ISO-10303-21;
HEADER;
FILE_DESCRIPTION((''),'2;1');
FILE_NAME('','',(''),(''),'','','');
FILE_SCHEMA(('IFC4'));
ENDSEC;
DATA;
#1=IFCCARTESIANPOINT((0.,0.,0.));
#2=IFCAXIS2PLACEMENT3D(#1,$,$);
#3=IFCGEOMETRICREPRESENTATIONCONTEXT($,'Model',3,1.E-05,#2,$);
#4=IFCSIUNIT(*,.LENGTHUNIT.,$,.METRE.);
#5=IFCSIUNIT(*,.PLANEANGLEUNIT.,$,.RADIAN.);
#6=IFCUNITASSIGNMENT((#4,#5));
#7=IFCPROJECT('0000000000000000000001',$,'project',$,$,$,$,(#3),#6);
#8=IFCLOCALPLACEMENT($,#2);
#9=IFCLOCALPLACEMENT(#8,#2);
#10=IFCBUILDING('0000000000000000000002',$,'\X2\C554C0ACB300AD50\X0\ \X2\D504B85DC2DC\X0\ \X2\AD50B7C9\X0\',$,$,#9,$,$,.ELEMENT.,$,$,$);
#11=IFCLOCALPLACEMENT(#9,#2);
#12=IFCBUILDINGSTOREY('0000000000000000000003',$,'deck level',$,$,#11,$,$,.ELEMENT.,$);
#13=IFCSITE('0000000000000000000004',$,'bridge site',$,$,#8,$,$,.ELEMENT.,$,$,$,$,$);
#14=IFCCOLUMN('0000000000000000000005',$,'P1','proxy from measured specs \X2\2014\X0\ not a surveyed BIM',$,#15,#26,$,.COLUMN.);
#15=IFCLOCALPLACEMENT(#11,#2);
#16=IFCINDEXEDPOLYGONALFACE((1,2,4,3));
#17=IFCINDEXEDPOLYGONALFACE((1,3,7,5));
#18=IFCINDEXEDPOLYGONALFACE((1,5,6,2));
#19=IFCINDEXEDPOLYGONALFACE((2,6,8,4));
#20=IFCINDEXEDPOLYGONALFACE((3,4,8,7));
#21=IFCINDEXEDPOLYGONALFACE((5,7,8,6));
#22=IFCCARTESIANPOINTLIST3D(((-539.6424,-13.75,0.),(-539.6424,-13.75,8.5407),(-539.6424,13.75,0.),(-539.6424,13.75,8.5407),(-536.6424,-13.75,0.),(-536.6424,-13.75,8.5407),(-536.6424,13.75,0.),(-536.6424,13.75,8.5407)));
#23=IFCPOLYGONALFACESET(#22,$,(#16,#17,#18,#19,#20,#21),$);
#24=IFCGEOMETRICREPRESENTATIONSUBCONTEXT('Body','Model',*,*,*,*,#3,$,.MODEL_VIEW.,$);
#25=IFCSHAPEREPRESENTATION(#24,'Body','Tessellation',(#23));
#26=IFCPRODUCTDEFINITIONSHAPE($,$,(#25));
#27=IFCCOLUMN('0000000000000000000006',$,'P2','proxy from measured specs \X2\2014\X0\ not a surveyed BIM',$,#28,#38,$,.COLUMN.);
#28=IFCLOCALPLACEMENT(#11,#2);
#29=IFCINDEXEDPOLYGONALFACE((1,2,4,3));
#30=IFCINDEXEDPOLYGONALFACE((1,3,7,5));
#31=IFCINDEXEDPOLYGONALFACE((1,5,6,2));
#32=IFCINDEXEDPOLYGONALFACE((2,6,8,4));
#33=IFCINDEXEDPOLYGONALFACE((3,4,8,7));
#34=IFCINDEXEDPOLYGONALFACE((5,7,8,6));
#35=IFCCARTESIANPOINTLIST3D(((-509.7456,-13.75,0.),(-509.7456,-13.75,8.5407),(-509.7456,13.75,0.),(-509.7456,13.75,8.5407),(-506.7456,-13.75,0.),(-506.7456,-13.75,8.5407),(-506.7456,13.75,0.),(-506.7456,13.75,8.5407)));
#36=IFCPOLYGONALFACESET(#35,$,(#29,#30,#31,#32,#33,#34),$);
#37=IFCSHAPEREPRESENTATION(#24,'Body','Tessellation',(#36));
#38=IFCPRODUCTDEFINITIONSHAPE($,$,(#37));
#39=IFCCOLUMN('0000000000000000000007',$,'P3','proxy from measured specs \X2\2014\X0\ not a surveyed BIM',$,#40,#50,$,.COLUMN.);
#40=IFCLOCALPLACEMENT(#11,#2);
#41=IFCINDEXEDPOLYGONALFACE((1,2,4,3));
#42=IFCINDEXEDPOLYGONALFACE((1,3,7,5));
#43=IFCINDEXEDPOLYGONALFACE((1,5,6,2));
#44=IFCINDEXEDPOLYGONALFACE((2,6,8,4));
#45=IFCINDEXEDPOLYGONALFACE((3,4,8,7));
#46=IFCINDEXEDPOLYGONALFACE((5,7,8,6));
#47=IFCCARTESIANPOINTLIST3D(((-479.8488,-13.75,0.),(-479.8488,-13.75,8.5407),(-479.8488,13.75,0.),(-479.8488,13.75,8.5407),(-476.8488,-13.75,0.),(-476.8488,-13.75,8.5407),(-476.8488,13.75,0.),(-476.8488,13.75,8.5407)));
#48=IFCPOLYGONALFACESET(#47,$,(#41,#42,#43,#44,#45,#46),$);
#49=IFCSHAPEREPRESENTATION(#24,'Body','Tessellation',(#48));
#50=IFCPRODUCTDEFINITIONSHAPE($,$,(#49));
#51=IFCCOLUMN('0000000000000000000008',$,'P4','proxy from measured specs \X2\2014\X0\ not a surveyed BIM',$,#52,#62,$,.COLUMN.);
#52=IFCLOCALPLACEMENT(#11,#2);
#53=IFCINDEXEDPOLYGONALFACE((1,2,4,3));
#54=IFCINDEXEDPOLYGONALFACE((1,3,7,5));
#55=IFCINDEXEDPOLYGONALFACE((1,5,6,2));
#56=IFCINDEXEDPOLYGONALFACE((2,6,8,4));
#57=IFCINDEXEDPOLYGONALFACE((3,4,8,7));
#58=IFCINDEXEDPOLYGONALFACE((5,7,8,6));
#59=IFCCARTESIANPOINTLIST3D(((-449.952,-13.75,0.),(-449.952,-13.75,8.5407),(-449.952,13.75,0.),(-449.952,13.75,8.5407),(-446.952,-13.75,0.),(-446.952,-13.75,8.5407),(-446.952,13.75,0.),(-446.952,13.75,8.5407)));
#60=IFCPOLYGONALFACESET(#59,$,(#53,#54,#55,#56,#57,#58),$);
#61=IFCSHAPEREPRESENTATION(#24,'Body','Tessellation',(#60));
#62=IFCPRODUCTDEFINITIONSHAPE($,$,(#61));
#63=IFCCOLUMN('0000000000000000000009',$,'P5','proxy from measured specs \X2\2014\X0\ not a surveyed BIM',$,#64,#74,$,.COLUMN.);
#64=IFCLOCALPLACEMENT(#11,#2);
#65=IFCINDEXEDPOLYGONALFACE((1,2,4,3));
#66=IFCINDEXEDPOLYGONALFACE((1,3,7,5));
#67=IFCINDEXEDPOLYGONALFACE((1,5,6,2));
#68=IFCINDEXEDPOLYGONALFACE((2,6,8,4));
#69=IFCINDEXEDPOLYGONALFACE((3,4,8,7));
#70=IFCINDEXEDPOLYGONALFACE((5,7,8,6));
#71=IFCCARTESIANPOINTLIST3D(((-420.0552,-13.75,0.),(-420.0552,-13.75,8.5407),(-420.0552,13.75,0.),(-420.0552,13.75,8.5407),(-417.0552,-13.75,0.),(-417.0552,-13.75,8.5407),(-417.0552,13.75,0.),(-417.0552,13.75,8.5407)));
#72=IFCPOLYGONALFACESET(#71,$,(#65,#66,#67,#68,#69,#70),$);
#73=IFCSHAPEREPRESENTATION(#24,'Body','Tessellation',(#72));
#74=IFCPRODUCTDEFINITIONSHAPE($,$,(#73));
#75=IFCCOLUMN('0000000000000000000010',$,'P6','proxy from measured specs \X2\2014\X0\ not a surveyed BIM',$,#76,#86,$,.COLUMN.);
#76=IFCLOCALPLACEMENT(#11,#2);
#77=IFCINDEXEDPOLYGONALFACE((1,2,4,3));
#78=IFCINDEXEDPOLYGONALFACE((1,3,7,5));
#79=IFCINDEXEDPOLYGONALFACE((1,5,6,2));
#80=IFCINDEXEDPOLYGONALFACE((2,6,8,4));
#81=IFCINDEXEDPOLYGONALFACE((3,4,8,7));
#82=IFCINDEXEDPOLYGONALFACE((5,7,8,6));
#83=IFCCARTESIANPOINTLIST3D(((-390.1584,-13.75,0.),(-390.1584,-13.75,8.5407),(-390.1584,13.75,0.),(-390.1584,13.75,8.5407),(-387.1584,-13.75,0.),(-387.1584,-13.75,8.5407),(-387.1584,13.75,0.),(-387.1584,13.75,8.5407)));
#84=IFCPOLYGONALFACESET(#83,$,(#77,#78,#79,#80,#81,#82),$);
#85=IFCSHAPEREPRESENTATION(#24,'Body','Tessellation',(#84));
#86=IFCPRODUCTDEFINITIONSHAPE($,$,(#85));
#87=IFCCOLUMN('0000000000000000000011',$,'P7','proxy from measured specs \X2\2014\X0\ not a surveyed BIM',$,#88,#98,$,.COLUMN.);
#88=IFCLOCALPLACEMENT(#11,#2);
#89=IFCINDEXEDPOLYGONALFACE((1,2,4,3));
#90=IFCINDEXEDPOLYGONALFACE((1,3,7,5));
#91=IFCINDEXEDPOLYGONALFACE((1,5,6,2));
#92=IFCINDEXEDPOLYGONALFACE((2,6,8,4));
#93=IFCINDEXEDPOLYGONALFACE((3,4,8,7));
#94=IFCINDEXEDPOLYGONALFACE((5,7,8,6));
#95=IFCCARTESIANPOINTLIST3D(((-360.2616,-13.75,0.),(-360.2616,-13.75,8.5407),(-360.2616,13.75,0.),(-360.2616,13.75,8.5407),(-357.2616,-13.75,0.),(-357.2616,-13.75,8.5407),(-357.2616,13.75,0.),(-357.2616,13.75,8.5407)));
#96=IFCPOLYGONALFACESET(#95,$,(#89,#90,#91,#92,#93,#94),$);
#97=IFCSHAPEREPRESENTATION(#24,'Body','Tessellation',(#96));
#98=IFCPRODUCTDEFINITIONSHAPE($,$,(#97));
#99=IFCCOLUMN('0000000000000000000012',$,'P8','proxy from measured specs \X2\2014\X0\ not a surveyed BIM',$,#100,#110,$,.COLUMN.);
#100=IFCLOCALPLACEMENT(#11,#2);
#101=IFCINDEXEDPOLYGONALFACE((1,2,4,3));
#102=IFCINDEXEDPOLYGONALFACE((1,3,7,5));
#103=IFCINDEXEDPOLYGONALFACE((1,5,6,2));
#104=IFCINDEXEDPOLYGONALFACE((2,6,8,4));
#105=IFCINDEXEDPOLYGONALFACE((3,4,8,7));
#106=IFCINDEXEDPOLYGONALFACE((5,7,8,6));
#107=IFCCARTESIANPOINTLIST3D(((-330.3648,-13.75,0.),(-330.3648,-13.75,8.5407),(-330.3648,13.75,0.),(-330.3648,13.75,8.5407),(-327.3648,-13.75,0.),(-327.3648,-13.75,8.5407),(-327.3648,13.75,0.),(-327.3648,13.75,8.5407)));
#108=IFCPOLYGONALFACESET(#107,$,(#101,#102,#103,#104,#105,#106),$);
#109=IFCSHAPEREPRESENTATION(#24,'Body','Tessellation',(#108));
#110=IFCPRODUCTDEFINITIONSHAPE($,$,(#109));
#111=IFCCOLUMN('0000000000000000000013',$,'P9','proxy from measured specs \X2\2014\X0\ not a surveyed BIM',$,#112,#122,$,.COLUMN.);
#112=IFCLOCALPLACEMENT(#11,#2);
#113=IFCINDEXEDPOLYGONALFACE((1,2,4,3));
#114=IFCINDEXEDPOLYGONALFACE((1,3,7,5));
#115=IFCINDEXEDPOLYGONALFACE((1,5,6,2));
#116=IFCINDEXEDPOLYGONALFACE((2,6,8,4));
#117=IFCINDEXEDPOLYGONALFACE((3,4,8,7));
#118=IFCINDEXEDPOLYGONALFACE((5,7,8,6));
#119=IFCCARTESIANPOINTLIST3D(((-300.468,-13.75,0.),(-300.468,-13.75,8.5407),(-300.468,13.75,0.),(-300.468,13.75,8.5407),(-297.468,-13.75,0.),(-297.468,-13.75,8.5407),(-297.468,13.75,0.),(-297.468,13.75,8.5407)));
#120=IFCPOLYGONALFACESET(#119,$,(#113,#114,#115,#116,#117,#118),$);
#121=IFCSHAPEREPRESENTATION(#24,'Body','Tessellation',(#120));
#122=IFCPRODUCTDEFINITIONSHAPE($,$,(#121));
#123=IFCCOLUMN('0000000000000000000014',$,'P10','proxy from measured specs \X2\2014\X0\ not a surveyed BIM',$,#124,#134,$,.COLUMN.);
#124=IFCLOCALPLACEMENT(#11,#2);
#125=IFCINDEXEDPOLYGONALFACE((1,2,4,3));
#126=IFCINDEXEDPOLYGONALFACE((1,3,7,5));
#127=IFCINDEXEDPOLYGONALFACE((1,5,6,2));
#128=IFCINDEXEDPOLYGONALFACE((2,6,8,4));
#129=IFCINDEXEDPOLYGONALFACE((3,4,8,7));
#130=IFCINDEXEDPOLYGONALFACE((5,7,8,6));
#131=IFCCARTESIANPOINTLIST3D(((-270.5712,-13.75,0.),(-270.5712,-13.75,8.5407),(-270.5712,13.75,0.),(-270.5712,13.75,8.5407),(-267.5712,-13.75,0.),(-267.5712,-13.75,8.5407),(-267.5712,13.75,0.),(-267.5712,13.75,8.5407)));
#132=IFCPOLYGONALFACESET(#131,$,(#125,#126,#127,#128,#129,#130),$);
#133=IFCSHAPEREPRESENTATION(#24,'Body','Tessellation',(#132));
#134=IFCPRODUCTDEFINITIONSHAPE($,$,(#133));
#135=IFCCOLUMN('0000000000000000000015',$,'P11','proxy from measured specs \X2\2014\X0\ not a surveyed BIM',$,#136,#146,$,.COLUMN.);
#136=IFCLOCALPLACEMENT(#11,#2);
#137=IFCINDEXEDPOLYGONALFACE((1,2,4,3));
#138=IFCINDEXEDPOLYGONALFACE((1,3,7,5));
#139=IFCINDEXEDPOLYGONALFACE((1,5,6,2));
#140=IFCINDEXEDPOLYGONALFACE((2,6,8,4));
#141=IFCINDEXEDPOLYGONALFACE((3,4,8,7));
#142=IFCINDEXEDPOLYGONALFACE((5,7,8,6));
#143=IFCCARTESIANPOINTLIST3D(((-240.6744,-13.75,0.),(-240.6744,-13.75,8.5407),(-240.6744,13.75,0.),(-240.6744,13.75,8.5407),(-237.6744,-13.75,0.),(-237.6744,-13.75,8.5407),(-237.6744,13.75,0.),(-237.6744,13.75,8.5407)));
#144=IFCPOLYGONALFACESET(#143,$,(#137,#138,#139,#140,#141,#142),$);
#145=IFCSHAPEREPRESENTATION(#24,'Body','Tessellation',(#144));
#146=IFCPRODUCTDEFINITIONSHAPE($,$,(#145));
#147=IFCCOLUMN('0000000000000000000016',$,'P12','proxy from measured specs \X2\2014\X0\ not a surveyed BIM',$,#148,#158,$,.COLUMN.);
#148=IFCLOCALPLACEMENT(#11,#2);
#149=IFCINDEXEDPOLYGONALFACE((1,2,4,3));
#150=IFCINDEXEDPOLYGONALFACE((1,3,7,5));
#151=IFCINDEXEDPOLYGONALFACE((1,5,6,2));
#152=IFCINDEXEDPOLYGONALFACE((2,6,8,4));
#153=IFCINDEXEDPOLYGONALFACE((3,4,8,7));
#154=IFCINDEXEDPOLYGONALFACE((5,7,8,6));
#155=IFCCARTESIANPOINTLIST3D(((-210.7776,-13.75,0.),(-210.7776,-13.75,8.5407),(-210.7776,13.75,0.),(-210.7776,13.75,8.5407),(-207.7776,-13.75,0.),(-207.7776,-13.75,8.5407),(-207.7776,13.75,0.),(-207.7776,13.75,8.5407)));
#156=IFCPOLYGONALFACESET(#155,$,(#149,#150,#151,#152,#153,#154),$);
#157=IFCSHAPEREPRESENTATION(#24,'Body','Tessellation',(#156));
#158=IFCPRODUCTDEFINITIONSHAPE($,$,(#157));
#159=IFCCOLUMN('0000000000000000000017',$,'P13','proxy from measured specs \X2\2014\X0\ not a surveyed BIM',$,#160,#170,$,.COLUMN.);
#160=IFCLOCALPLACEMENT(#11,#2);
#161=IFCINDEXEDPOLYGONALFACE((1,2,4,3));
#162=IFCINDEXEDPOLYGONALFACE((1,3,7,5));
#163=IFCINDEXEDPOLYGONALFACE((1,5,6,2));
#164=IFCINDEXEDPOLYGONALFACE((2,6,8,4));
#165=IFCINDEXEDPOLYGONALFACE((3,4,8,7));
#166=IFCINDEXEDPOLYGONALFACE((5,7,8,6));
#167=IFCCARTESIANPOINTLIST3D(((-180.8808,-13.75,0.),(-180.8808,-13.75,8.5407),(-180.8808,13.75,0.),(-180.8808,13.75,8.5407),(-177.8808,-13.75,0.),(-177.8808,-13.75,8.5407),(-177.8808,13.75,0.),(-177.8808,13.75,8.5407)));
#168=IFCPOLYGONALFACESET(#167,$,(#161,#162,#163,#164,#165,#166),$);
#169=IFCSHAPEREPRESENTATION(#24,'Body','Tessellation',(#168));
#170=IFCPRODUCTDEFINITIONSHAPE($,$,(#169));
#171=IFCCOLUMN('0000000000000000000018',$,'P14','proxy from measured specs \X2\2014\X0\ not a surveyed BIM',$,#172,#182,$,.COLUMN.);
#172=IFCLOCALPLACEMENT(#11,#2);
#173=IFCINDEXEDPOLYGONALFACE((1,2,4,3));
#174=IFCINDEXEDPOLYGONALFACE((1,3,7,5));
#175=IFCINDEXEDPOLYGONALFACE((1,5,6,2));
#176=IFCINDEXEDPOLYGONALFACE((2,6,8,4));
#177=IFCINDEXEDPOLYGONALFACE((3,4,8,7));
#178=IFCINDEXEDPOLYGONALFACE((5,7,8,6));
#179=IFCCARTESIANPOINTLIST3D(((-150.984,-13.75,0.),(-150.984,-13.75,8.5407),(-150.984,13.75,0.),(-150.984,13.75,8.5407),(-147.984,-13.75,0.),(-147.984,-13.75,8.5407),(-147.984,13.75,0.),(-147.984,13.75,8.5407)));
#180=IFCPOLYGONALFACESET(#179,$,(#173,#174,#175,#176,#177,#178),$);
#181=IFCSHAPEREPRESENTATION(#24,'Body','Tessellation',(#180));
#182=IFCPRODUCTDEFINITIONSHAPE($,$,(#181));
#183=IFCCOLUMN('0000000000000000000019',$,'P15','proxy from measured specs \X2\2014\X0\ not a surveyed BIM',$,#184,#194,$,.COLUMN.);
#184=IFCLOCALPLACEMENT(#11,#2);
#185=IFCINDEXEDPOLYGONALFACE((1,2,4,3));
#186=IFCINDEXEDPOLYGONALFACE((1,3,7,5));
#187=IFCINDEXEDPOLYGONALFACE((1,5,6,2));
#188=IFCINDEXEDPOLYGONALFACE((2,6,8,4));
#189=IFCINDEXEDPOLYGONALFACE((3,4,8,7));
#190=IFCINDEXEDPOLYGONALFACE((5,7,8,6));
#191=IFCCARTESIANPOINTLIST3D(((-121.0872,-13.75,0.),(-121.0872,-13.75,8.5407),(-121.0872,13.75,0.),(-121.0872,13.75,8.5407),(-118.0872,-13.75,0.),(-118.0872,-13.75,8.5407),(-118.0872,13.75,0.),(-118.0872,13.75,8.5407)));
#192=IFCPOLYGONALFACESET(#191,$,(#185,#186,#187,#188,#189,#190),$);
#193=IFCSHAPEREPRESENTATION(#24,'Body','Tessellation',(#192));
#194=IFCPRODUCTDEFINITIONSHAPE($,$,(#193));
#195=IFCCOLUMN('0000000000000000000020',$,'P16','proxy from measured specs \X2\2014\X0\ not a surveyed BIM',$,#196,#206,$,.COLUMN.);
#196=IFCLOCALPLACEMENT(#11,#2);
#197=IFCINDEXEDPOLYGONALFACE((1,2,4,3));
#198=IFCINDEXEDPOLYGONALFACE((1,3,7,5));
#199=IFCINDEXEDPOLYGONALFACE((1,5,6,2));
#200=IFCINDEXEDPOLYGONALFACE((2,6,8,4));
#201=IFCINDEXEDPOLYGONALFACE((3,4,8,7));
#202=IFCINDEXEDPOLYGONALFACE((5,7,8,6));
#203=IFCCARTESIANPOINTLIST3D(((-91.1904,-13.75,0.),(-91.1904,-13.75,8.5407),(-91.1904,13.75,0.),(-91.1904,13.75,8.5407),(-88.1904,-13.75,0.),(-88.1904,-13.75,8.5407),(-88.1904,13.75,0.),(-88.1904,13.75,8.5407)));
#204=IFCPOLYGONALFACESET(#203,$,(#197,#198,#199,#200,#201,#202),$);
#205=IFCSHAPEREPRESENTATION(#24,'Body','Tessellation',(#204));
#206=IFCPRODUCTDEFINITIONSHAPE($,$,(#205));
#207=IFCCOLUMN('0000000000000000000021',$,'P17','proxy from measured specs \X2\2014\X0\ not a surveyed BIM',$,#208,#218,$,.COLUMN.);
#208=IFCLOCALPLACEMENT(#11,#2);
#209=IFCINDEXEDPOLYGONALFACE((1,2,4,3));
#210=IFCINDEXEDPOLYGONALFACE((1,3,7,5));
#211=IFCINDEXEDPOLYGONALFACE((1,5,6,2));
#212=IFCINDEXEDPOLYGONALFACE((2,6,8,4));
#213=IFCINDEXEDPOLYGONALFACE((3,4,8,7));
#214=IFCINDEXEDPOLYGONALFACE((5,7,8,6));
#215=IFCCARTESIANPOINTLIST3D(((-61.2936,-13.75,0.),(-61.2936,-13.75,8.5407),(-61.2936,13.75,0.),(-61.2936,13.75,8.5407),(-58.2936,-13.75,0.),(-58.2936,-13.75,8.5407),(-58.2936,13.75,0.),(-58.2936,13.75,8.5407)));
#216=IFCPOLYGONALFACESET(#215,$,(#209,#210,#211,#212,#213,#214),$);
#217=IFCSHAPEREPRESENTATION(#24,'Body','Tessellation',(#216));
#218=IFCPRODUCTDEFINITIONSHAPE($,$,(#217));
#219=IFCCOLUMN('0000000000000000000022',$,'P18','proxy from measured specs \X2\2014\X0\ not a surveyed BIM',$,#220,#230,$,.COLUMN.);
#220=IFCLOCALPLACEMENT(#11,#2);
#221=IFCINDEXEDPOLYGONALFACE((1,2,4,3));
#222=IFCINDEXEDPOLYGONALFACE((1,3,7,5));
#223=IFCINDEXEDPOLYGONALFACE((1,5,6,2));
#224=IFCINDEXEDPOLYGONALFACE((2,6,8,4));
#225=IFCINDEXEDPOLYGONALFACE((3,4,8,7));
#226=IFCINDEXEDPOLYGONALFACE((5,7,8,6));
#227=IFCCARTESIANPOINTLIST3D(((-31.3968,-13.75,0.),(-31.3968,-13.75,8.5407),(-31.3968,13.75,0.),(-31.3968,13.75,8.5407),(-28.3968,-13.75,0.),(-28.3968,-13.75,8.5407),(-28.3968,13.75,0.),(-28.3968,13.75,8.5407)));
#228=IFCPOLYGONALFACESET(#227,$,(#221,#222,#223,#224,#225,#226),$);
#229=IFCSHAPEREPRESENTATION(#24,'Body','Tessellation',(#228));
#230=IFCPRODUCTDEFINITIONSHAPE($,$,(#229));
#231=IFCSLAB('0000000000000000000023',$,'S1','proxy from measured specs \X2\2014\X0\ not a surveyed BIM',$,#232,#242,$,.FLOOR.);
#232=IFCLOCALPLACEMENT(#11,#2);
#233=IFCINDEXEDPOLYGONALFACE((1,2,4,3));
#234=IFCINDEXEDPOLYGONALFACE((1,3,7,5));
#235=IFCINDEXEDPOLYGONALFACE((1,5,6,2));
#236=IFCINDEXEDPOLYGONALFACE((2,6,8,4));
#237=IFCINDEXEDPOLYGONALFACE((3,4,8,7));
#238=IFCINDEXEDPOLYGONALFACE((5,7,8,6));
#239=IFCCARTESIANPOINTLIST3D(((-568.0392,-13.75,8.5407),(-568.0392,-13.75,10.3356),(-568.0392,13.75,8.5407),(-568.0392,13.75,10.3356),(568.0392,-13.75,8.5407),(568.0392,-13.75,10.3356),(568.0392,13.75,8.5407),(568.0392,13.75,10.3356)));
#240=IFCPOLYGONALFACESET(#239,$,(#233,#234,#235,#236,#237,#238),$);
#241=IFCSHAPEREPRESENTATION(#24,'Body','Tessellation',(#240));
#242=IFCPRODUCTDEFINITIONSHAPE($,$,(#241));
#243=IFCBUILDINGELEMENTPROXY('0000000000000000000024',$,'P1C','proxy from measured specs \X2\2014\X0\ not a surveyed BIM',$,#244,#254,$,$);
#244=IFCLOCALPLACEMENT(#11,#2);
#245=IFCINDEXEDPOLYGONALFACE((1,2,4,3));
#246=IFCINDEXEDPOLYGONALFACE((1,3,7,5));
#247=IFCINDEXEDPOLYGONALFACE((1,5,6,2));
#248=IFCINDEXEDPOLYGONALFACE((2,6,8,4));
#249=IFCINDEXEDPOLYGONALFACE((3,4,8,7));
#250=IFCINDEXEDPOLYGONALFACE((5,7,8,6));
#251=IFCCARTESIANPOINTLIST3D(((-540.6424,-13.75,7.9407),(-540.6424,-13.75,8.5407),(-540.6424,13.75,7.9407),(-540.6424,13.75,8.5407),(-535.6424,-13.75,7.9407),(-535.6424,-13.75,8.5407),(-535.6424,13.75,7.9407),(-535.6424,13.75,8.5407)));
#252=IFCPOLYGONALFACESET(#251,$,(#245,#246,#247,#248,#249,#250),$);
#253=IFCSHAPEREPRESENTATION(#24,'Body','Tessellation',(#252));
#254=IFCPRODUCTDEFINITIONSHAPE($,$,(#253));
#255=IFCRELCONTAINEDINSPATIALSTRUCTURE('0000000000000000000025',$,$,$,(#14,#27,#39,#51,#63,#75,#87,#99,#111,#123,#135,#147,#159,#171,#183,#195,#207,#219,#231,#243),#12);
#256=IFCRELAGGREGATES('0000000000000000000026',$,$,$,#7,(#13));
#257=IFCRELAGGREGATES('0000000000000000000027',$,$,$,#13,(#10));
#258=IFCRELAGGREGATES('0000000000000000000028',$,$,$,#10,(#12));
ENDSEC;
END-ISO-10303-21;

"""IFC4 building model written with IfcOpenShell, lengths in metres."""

from ifc_helpers import new_model, si_unit, frame, origin, origin_2d, place, context, subcontext, project, spatial, rectangle, extrude, element, save


model = new_model("IFC4")

# Units and contexts
model_context = context("Model", 3, precision=1e-05, world=origin())
body_context = subcontext(model_context, "Body", "Model", "MODEL_VIEW")
ifc_project = project(units=[si_unit("LENGTHUNIT", "METRE"), si_unit("PLANEANGLEUNIT", "RADIAN")], contexts=[model_context])

# Site, building, storey
site_placement = place(None, origin())
site = spatial("IfcSite", under=ifc_project, at=site_placement, Name="bridge site", CompositionType="ELEMENT")
building_placement = place(site_placement, origin())
building = spatial("IfcBuilding", under=site, at=building_placement, Name="암사대교 프록시 교량", CompositionType="ELEMENT")
storey_placement = place(building_placement, origin())
storey = spatial("IfcBuildingStorey", under=building, at=storey_placement, Name="deck level", CompositionType="ELEMENT")

# Columns
for number, where, name in (
    (1, (-538.1424, 0.0, 0.0), "P1"),
    (2, (-508.2456, 0.0, 0.0), "P2"),
    (3, (-478.3488, 0.0, 0.0), "P3"),
    (4, (-448.452, 0.0, 0.0), "P4"),
    (5, (-418.5552, 0.0, 0.0), "P5"),
    (6, (-388.6584, 0.0, 0.0), "P6"),
    (7, (-358.7616, 0.0, 0.0), "P7"),
    (8, (-328.8648, 0.0, 0.0), "P8"),
    (9, (-298.968, 0.0, 0.0), "P9"),
    (10, (-269.0712, 0.0, 0.0), "P10"),
    (11, (-239.1744, 0.0, 0.0), "P11"),
    (12, (-209.2776, 0.0, 0.0), "P12"),
    (13, (-179.3808, 0.0, 0.0), "P13"),
    (14, (-149.484, 0.0, 0.0), "P14"),
    (15, (-119.5872, 0.0, 0.0), "P15"),
    (16, (-89.6904, 0.0, 0.0), "P16"),
    (17, (-59.7936, 0.0, 0.0), "P17"),
    (18, (-29.8968, 0.0, 0.0), "P18"),
):
    element("IfcColumn", number, at=place(storey_placement, frame(where)), inside=storey, Name=name, Description="proxy from measured specs — not a surveyed BIM", PredefinedType="COLUMN", context=body_context, shape_type="SweptSolid", body=[
        extrude(rectangle(XDim=3.0, YDim=27.5, at=origin_2d()), origin(), (0.0, 0.0, 1.0), 8.5407),
    ])

# Slab
slab_placement = place(storey_placement, frame((0.0, 0.0, 8.5407)))
element("IfcSlab", 19, at=slab_placement, inside=storey, Name="S1", Description="proxy from measured specs — not a surveyed BIM", PredefinedType="FLOOR", context=body_context, shape_type="SweptSolid", body=[
    extrude(rectangle(XDim=1136.0784, YDim=27.5, at=origin_2d()), origin(), (0.0, 0.0, 1.0), 1.7948),
])

# Building element proxy
for number, where, name in (
    (20, (-538.1424, 0.0, 7.9407), "P1C"),
):
    element("IfcBuildingElementProxy", number, at=place(storey_placement, frame(where)), inside=storey, Name=name, Description="proxy from measured specs — not a surveyed BIM", context=body_context, shape_type="SweptSolid", body=[
        extrude(rectangle(XDim=5.0, YDim=27.5, at=origin_2d()), origin(), (0.0, 0.0, 1.0), 0.6),
    ])

save(model, "model.ifc")
